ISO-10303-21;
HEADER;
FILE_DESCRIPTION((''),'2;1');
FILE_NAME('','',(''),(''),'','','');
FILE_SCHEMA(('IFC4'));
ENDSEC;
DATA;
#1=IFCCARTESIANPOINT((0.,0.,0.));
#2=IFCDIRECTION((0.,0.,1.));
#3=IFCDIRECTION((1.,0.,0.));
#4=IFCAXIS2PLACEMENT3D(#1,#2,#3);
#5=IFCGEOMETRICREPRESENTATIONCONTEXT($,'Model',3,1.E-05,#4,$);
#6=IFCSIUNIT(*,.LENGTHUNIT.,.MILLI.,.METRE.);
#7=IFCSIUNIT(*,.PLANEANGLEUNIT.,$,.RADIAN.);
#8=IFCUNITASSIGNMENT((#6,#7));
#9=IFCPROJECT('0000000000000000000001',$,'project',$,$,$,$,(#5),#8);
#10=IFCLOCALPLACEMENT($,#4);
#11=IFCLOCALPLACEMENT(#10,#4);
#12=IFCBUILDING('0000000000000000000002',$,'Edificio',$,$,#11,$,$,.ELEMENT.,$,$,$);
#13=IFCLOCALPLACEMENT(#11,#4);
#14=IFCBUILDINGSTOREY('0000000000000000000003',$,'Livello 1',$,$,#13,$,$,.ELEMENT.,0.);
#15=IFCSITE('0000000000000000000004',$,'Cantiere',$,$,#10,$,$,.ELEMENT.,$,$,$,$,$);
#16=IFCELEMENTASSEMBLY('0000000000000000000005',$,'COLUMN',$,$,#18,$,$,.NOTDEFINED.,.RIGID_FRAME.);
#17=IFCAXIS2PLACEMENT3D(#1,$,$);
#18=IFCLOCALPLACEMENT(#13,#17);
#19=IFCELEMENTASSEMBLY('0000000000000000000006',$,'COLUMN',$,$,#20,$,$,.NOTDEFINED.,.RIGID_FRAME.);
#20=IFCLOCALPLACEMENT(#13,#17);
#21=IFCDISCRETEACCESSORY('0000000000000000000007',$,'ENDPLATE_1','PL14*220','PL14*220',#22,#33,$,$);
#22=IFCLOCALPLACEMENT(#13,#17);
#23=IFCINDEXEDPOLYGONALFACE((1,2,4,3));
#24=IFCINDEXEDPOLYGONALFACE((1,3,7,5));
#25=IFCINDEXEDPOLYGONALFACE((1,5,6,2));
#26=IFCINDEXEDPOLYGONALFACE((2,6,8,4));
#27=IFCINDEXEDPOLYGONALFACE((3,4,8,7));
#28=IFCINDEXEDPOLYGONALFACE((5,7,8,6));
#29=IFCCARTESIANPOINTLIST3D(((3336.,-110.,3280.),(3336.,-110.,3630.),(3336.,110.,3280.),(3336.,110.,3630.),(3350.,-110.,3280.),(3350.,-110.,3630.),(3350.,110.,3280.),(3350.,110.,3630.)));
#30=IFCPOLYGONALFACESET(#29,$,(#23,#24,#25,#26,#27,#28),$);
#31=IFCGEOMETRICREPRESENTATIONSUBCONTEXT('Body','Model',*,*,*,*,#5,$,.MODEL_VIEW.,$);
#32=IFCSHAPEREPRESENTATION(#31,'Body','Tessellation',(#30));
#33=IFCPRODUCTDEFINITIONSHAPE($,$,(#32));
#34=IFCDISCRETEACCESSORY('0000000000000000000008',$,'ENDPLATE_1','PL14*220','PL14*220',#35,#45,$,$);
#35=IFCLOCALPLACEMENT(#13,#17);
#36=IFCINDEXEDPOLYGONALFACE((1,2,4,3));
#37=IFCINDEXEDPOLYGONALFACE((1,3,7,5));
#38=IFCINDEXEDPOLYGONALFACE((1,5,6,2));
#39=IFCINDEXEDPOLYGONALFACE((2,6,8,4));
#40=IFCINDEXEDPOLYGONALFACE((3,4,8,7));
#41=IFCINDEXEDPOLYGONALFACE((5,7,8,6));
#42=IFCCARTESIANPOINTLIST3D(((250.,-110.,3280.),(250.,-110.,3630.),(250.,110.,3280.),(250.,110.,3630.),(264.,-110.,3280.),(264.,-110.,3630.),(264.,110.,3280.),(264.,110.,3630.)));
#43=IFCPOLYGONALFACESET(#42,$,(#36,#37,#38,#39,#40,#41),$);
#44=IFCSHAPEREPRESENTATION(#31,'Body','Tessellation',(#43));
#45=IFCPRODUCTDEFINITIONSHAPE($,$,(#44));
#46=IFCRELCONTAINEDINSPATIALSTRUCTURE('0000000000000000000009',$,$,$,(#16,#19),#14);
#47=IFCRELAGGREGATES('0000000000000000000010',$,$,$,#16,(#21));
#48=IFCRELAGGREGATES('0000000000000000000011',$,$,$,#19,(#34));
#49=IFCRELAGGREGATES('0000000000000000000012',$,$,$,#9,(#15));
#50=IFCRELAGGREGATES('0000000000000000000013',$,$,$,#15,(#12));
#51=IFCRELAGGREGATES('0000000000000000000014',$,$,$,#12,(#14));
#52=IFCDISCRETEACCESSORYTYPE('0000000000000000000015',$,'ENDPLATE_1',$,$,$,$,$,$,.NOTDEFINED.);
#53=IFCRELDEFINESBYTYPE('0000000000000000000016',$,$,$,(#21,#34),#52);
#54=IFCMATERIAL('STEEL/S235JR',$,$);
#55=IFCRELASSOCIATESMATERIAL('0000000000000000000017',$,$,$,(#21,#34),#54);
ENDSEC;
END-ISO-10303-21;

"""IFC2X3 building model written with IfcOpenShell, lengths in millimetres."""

from ifc_helpers import new_model, si_unit, frame, origin_with_axes, place, context, subcontext, project, spatial, polyline, outline, extrude, material, type_object, element, aggregate, save


model = new_model("IFC2X3")

# Units and contexts
model_context = context("Model", 3, precision=1e-05, world=origin_with_axes())
body_context = subcontext(model_context, "Body", "Model", "MODEL_VIEW")
ifc_project = project(units=[si_unit("LENGTHUNIT", "METRE", prefix="MILLI"), si_unit("PLANEANGLEUNIT", "RADIAN")], contexts=[model_context])

# Site, building, storey
site_placement = place(None, origin_with_axes())
site = spatial("IfcSite", under=ifc_project, at=site_placement, Name="Cantiere", CompositionType="ELEMENT")
building_placement = place(site_placement, origin_with_axes())
building = spatial("IfcBuilding", under=site, at=building_placement, Name="Edificio", CompositionType="ELEMENT")
storey_placement = place(building_placement, origin_with_axes())
storey = spatial("IfcBuildingStorey", under=building, at=storey_placement, Name="Livello 1", CompositionType="ELEMENT", Elevation=0.0)

# Shared definitions
ifc_material_1 = material(Name="STEEL/S235JR")

# Element assembly
assembly_1_placement = place(storey_placement, origin_with_axes())
assembly_1 = element("IfcElementAssembly", 1, at=assembly_1_placement, inside=storey, Name="COLUMN", AssemblyPlace="NOTDEFINED", PredefinedType="RIGID_FRAME")

# Element assembly
assembly_2_placement = place(storey_placement, origin_with_axes())
assembly_2 = element("IfcElementAssembly", 2, at=assembly_2_placement, inside=storey, Name="COLUMN", AssemblyPlace="NOTDEFINED", PredefinedType="RIGID_FRAME")

# Discrete accessories
discrete_accessory_type_1 = type_object("IfcDiscreteAccessoryType", Name="ENDPLATE_1")
discrete_accessory_1_placement = place(assembly_1_placement, frame((3343.0, -110.0, 3280.0), z_axis=(-1.0, 0.0, 0.0), x_axis=(0.0, 0.0, 1.0)))
discrete_accessory_1 = element("IfcDiscreteAccessory", 3, at=discrete_accessory_1_placement, type_object=discrete_accessory_type_1, material=ifc_material_1, Name="ENDPLATE_1", Description="PL14*220", ObjectType="PL14*220", context=body_context, shape_type="SweptSolid", body=[
    extrude(outline(polyline([(0.0, 0.0), (350.0, 0.0), (350.0, 220.0), (0.0, 220.0), (0.0, 0.0)])), frame((0.0, 0.0, -7.0), z_axis=(0.0, 0.0, 1.0), x_axis=(1.0, 0.0, 0.0)), (0.0, 0.0, 1.0), 14.0),
])
aggregate(assembly_1, [discrete_accessory_1])
discrete_accessory_2_placement = place(assembly_2_placement, frame((257.0, 110.0, 3280.0), z_axis=(1.0, 0.0, 0.0), x_axis=(0.0, 0.0, 1.0)))
discrete_accessory_2 = element("IfcDiscreteAccessory", 4, at=discrete_accessory_2_placement, type_object=discrete_accessory_type_1, material=ifc_material_1, Name="ENDPLATE_1", Description="PL14*220", ObjectType="PL14*220", context=body_context, shape_type="SweptSolid", body=[
    extrude(outline(polyline([(0.0, 0.0), (350.0, 0.0), (350.0, 220.0), (0.0, 220.0), (0.0, 0.0)])), frame((0.0, 0.0, -7.0), z_axis=(0.0, 0.0, 1.0), x_axis=(1.0, 0.0, 0.0)), (0.0, 0.0, 1.0), 14.0),
])
aggregate(assembly_2, [discrete_accessory_2])

save(model, "model.ifc")
